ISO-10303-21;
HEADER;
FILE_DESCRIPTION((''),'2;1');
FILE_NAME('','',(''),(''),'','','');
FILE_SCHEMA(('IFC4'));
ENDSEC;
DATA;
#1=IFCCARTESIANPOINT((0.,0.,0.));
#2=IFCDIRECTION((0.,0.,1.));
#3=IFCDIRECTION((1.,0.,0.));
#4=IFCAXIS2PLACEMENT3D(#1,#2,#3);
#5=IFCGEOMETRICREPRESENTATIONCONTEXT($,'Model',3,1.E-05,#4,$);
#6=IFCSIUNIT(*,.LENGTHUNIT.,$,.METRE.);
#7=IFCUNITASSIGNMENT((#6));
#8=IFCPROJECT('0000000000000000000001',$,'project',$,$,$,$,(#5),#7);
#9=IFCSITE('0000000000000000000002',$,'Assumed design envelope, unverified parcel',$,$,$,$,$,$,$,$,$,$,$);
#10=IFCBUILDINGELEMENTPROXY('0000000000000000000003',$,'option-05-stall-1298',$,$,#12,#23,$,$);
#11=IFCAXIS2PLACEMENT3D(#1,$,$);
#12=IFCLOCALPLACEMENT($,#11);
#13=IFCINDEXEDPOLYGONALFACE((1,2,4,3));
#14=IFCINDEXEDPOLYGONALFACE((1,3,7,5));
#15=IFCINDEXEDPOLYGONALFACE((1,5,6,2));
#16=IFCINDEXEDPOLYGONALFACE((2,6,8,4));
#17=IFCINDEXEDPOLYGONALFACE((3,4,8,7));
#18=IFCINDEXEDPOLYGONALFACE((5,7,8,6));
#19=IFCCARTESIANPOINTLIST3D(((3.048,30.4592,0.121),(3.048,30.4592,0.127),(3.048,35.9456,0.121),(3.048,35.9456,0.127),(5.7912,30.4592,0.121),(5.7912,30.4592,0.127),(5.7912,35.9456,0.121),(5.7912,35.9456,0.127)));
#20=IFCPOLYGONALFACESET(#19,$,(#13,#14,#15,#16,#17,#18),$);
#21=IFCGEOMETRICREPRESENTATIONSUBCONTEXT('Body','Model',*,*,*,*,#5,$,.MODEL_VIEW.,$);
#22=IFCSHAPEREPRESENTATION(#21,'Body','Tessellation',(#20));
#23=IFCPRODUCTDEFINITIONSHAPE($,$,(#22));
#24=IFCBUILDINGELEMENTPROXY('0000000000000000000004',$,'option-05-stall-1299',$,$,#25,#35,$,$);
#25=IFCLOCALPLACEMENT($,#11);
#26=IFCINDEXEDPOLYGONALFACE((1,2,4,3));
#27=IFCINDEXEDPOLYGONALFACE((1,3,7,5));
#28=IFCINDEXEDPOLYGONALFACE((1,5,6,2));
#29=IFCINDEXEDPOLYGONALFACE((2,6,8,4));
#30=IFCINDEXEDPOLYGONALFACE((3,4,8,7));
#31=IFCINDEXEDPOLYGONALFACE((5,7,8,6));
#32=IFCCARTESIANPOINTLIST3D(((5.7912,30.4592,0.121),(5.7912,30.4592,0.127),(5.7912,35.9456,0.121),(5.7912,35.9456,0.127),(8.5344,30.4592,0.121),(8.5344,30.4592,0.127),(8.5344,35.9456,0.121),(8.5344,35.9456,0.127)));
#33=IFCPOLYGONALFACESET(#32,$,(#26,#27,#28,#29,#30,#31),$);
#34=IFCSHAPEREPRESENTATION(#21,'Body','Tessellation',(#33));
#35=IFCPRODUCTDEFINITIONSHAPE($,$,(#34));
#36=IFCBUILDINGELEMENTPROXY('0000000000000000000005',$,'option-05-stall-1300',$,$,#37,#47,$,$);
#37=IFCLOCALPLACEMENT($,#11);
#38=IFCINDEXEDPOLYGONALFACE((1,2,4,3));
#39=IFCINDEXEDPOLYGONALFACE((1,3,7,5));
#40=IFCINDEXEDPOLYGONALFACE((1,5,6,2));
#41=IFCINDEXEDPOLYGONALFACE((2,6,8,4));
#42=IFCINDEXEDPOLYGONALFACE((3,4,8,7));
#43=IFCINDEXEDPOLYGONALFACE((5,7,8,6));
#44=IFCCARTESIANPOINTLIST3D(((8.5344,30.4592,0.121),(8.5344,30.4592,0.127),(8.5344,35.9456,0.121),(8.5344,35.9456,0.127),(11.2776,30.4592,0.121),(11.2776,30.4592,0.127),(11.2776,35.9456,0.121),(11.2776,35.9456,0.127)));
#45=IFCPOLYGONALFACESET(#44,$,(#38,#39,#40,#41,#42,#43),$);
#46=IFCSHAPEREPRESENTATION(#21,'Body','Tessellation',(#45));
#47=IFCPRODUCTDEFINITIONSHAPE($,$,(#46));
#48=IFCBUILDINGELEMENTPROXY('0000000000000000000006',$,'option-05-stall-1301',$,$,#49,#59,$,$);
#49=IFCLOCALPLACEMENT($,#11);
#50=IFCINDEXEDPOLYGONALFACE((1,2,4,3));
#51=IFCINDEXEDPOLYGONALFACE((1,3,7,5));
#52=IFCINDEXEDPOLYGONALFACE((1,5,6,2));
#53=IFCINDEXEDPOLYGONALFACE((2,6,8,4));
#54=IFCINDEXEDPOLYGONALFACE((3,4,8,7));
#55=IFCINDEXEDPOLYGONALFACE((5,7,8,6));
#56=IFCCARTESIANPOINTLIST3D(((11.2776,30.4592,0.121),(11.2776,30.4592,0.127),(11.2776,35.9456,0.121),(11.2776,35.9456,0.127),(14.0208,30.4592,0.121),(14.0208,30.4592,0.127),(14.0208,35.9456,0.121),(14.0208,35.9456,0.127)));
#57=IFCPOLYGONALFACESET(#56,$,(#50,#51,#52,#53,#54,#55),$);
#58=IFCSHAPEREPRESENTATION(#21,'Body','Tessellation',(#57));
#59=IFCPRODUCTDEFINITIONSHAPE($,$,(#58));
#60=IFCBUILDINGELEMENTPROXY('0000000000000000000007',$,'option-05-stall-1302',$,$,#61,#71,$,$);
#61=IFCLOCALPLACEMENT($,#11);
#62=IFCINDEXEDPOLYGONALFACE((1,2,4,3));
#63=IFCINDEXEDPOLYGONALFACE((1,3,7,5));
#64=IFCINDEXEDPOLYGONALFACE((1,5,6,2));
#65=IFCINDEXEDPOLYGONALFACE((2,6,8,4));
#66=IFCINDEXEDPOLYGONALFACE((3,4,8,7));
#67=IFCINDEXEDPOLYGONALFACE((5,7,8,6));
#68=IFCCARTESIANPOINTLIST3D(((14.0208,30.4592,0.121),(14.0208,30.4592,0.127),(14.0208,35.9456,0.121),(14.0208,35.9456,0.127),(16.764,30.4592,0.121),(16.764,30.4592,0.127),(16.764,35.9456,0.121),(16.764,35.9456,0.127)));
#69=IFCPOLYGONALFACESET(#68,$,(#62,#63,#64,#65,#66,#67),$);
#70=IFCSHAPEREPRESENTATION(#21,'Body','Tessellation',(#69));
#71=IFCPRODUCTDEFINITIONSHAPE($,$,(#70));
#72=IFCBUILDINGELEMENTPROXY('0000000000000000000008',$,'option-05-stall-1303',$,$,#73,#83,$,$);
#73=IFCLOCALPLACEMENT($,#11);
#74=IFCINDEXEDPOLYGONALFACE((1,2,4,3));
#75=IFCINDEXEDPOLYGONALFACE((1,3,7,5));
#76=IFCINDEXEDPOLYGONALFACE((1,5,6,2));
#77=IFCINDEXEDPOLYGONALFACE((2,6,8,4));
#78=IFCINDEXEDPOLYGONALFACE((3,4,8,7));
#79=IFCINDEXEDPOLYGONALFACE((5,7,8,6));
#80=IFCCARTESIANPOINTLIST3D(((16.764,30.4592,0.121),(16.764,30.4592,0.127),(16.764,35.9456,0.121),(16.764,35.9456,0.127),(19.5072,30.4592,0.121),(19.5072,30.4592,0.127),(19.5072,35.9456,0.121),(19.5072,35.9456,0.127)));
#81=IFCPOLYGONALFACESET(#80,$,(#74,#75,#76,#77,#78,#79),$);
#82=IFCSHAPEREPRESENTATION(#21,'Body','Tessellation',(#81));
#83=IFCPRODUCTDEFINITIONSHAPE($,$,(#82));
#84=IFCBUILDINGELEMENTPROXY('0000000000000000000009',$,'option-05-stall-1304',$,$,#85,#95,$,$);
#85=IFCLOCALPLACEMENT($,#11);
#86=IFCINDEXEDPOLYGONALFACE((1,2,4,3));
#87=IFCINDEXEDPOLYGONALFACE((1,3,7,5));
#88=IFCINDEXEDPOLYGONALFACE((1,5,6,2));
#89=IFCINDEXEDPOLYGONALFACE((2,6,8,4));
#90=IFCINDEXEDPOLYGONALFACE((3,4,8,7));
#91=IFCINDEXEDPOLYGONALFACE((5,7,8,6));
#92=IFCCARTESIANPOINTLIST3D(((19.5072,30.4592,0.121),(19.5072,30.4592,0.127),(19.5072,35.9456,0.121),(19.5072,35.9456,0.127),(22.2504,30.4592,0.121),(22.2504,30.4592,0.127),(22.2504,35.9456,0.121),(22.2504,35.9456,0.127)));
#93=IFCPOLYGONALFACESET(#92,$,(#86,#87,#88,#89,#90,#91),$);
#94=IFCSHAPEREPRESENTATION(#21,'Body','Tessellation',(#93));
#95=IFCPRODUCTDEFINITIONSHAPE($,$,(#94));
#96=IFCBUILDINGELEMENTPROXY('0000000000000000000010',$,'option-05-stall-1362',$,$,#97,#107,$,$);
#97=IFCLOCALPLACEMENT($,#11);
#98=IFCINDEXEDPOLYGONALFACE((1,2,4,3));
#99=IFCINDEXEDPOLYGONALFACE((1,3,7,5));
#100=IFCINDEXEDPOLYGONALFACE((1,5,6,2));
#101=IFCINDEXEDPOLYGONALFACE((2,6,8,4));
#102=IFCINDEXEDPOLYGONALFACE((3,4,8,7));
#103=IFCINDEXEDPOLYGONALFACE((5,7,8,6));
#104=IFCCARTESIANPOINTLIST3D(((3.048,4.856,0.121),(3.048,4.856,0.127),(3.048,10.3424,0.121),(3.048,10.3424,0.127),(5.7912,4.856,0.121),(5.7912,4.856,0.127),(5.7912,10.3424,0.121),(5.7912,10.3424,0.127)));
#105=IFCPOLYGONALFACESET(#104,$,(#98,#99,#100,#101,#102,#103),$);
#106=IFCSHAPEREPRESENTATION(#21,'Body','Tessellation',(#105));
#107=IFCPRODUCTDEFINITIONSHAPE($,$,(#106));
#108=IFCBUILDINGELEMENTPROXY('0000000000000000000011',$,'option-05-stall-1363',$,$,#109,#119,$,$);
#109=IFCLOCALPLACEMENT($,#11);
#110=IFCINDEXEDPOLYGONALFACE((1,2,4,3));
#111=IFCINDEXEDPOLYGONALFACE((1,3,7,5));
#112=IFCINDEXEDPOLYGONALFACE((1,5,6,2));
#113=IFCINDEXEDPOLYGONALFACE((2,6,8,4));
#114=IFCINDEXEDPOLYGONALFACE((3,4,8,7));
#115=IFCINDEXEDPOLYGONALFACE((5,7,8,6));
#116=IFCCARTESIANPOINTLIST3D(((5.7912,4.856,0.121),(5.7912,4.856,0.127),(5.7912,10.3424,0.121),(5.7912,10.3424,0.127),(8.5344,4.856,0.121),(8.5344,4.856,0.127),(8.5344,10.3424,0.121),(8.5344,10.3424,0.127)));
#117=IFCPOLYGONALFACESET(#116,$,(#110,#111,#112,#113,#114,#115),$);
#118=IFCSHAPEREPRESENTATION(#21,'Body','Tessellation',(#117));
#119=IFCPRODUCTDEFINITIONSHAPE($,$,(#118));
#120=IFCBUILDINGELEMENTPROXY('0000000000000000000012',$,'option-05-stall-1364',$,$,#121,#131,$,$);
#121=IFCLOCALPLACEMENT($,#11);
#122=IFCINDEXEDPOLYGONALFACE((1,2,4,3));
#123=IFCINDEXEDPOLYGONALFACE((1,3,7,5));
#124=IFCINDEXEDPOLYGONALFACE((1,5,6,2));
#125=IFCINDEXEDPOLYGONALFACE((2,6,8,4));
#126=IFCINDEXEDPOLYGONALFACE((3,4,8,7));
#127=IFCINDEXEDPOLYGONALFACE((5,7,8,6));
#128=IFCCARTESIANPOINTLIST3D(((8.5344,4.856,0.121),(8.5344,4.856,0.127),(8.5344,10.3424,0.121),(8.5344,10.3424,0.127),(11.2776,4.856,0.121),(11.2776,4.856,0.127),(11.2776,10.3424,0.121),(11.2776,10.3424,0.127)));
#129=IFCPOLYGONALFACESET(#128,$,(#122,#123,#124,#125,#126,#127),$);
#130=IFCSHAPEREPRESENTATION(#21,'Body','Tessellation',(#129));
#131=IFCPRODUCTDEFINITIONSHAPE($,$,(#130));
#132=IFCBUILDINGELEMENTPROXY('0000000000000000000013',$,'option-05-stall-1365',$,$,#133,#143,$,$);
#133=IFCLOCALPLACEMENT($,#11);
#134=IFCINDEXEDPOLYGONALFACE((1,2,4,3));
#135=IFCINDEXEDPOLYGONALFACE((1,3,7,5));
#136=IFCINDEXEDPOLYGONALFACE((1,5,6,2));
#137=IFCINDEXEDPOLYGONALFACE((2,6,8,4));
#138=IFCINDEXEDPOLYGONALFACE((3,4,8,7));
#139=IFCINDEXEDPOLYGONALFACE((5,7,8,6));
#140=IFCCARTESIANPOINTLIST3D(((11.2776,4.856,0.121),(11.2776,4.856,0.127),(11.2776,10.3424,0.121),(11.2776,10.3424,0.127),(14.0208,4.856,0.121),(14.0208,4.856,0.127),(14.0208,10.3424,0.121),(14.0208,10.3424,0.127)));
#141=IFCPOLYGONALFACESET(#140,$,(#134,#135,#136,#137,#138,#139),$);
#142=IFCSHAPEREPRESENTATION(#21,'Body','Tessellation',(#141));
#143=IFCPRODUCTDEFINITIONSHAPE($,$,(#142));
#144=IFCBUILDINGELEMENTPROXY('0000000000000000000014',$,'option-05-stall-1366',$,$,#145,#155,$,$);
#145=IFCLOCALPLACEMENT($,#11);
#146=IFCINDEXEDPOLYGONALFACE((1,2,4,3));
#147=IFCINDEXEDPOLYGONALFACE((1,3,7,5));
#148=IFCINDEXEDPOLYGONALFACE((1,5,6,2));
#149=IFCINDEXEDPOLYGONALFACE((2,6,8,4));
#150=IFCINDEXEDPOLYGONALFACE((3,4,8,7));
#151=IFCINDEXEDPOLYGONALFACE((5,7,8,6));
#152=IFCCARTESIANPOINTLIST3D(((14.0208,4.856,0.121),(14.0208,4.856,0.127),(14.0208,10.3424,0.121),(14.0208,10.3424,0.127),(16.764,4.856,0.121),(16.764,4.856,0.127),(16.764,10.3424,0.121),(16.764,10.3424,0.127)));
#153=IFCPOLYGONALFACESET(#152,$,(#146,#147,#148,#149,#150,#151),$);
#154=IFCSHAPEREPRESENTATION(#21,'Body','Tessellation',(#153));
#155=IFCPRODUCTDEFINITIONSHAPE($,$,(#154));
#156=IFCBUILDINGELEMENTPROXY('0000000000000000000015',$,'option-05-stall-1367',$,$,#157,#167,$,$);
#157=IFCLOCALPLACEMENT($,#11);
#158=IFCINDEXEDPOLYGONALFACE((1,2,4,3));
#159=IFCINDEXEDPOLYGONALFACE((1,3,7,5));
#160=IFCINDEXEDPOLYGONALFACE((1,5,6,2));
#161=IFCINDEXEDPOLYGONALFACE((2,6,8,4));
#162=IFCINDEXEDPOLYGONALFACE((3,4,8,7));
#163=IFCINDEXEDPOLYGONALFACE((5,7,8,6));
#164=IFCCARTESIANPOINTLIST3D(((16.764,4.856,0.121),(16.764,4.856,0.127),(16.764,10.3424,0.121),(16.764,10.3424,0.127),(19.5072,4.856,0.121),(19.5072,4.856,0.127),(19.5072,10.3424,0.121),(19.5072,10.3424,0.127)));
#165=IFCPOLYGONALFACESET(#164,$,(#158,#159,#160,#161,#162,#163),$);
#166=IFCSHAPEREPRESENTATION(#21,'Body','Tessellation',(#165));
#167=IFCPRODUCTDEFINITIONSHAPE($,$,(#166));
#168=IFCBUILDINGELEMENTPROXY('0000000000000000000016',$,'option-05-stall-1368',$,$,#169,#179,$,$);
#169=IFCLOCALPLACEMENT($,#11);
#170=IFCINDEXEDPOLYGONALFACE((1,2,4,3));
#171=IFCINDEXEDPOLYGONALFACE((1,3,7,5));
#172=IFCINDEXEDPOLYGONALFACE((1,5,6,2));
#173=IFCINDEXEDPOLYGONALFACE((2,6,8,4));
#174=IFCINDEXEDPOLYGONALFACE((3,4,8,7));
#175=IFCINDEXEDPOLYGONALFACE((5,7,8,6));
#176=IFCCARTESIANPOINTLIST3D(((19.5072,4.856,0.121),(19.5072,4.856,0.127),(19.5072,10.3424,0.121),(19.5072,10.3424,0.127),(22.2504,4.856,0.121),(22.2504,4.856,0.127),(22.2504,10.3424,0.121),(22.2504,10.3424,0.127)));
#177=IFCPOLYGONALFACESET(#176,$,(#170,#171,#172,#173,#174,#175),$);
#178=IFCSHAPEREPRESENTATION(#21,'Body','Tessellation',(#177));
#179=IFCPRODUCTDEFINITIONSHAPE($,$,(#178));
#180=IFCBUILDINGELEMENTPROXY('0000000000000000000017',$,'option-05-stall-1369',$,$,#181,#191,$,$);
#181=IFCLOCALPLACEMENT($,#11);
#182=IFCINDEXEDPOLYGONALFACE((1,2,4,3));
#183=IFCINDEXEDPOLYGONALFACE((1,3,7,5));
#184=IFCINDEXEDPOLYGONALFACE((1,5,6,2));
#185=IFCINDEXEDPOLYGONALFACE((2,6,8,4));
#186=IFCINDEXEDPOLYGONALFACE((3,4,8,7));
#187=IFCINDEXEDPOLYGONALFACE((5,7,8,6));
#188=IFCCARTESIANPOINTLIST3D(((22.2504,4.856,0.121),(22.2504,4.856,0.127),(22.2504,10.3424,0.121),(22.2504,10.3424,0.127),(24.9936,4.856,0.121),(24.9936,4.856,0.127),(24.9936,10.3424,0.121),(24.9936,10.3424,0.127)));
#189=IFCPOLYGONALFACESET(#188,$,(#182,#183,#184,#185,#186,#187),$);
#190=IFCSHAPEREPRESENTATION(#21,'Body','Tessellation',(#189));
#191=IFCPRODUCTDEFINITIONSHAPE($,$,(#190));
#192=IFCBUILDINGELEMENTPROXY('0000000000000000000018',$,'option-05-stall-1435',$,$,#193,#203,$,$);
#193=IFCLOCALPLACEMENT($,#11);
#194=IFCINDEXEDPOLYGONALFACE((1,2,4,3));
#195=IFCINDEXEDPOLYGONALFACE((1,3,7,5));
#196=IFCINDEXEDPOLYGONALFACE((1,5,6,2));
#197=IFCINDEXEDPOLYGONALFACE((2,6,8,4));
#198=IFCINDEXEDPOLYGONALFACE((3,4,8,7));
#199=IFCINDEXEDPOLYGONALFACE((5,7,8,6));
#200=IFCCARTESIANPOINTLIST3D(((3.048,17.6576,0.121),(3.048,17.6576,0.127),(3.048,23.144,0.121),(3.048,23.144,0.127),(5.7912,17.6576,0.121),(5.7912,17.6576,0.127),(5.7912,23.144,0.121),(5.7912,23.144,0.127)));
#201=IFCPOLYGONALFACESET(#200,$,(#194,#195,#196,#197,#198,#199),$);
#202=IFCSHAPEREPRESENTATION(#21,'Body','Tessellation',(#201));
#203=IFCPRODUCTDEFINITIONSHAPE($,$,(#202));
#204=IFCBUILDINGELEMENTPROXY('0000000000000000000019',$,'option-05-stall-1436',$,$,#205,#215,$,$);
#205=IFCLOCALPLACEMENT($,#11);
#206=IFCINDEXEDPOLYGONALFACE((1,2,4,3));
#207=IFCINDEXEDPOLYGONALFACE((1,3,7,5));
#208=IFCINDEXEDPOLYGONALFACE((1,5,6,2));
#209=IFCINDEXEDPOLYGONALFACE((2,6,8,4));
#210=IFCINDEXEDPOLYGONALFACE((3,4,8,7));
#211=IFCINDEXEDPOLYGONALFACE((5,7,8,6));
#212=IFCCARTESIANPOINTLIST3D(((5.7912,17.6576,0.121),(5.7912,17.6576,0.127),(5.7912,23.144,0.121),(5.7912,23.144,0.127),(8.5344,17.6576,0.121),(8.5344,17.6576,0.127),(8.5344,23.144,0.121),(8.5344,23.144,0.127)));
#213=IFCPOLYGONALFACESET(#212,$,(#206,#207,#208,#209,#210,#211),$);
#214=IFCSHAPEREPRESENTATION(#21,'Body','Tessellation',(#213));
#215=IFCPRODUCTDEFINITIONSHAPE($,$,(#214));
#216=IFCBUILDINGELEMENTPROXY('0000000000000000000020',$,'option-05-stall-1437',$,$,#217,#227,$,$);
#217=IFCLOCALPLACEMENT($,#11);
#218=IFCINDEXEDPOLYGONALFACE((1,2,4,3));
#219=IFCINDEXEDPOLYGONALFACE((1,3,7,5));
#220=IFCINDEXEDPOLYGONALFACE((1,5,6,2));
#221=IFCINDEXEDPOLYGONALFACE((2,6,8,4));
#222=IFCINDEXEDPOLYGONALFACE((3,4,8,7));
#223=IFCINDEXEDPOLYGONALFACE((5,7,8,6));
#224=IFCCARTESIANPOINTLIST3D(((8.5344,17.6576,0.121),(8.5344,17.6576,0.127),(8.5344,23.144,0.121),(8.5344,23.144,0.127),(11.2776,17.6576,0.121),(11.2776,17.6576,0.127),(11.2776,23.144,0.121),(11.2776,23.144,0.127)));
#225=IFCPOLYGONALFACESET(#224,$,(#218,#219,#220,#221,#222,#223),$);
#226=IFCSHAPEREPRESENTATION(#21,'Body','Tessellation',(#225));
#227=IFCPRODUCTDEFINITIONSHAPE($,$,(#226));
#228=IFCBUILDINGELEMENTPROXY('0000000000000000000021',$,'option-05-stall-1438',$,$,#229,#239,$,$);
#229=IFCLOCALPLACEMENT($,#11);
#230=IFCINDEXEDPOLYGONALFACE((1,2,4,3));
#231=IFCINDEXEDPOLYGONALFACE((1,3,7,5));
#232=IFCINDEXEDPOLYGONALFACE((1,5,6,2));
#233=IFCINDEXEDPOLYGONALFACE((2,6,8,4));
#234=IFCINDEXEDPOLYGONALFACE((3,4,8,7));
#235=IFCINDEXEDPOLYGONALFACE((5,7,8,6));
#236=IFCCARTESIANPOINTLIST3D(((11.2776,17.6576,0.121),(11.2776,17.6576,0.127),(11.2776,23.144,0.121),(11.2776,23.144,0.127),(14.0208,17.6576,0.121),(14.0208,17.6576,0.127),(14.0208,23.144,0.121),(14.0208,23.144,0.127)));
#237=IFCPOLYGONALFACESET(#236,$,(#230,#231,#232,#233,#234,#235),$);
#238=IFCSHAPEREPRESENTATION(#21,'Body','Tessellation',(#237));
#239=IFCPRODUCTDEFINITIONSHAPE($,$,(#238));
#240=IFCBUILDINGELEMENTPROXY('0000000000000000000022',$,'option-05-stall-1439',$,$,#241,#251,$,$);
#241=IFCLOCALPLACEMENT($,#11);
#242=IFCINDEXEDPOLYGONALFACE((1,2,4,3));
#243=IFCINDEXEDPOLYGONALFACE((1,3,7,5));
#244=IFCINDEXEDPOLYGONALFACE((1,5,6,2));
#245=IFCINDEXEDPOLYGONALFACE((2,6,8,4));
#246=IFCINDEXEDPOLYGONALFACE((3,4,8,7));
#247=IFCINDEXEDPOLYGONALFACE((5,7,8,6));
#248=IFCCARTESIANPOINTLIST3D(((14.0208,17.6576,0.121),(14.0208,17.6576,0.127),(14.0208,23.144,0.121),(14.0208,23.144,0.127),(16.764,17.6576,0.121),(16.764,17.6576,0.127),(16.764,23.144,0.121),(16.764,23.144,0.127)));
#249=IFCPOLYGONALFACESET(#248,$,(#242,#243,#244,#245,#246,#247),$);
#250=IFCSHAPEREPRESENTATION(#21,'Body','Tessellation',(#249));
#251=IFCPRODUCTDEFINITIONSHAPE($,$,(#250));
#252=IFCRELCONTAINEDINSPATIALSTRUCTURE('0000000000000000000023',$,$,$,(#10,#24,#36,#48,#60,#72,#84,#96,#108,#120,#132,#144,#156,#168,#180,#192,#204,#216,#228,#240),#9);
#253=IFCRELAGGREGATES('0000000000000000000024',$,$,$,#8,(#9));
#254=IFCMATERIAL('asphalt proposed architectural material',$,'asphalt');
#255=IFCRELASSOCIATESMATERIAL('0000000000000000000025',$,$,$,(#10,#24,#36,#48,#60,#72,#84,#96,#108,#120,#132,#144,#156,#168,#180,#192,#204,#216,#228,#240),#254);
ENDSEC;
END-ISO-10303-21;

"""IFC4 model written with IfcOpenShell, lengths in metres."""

from ifc_helpers import new_model, si_unit, frame, origin_with_axes, place, context, subcontext, project, spatial, rectangle, extrude, material, element, save


model = new_model("IFC4")

# Units and contexts
model_context = context("Model", 3, precision=1e-05, world=origin_with_axes())
body_context = subcontext(model_context, "Body", "Model", "MODEL_VIEW")
ifc_project = project(units=[si_unit("LENGTHUNIT", "METRE")], contexts=[model_context])

# Site
site = spatial("IfcSite", under=ifc_project, Name="Assumed design envelope, unverified parcel")

# Building element proxies
ifc_material_1 = material(Name="asphalt proposed architectural material", Category="asphalt")
for number, where, z_axis, x_axis, name in (
    (1, (4.4196, 33.2024, 0.121), (0.0, 0.0, 1.0), (1.0, 0.0, 0.0), "option-05-stall-1298"),
    (2, (7.1628, 33.2024, 0.121), (0.0, 0.0, 1.0), (1.0, 0.0, 0.0), "option-05-stall-1299"),
    (3, (9.906, 33.2024, 0.121), (0.0, 0.0, 1.0), (1.0, 0.0, 0.0), "option-05-stall-1300"),
    (4, (12.6492, 33.2024, 0.121), (0.0, 0.0, 1.0), (1.0, 0.0, 0.0), "option-05-stall-1301"),
    (5, (15.3924, 33.2024, 0.121), (0.0, 0.0, 1.0), (1.0, 0.0, 0.0), "option-05-stall-1302"),
):
    element("IfcBuildingElementProxy", number, at=place(None, frame(where, z_axis=z_axis, x_axis=x_axis)), inside=site, material=ifc_material_1, Name=name, context=body_context, shape_type="SweptSolid", body=[
        extrude(rectangle(XDim=2.7432, YDim=5.4864), origin_with_axes(), (0.0, 0.0, 1.0), 0.006),
    ])
for number, where, z_axis, x_axis, name in (
    (6, (18.1356, 33.2024, 0.121), (0.0, 0.0, 1.0), (1.0, 0.0, 0.0), "option-05-stall-1303"),
    (7, (20.8788, 33.2024, 0.121), (0.0, 0.0, 1.0), (1.0, 0.0, 0.0), "option-05-stall-1304"),
):
    element("IfcBuildingElementProxy", number, at=place(None, frame(where, z_axis=z_axis, x_axis=x_axis)), inside=site, material=ifc_material_1, Name=name, context=body_context, shape_type="SweptSolid", body=[
        extrude(rectangle(XDim=2.7432, YDim=5.4864), origin_with_axes(), (0.0, 0.0, 1.0), 0.006),
    ])
for number, where, z_axis, x_axis, name in (
    (8, (4.4196, 7.5992, 0.121), (0.0, 0.0, 1.0), (1.0, 0.0, 0.0), "option-05-stall-1362"),
    (9, (7.1628, 7.5992, 0.121), (0.0, 0.0, 1.0), (1.0, 0.0, 0.0), "option-05-stall-1363"),
    (10, (9.906, 7.5992, 0.121), (0.0, 0.0, 1.0), (1.0, 0.0, 0.0), "option-05-stall-1364"),
    (11, (12.6492, 7.5992, 0.121), (0.0, 0.0, 1.0), (1.0, 0.0, 0.0), "option-05-stall-1365"),
    (12, (15.3924, 7.5992, 0.121), (0.0, 0.0, 1.0), (1.0, 0.0, 0.0), "option-05-stall-1366"),
):
    element("IfcBuildingElementProxy", number, at=place(None, frame(where, z_axis=z_axis, x_axis=x_axis)), inside=site, material=ifc_material_1, Name=name, context=body_context, shape_type="SweptSolid", body=[
        extrude(rectangle(XDim=2.7432, YDim=5.4864), origin_with_axes(), (0.0, 0.0, 1.0), 0.006),
    ])
for number, where, z_axis, x_axis, name in (
    (13, (18.1356, 7.5992, 0.121), (0.0, 0.0, 1.0), (1.0, 0.0, 0.0), "option-05-stall-1367"),
    (14, (20.8788, 7.5992, 0.121), (0.0, 0.0, 1.0), (1.0, 0.0, 0.0), "option-05-stall-1368"),
    (15, (23.622, 7.5992, 0.121), (0.0, 0.0, 1.0), (1.0, 0.0, 0.0), "option-05-stall-1369"),
):
    element("IfcBuildingElementProxy", number, at=place(None, frame(where, z_axis=z_axis, x_axis=x_axis)), inside=site, material=ifc_material_1, Name=name, context=body_context, shape_type="SweptSolid", body=[
        extrude(rectangle(XDim=2.7432, YDim=5.4864), origin_with_axes(), (0.0, 0.0, 1.0), 0.006),
    ])
for number, where, z_axis, x_axis, name in (
    (16, (4.4196, 20.4008, 0.121), (0.0, 0.0, 1.0), (1.0, 0.0, 0.0), "option-05-stall-1435"),
    (17, (7.1628, 20.4008, 0.121), (0.0, 0.0, 1.0), (1.0, 0.0, 0.0), "option-05-stall-1436"),
    (18, (9.906, 20.4008, 0.121), (0.0, 0.0, 1.0), (1.0, 0.0, 0.0), "option-05-stall-1437"),
    (19, (12.6492, 20.4008, 0.121), (0.0, 0.0, 1.0), (1.0, 0.0, 0.0), "option-05-stall-1438"),
    (20, (15.3924, 20.4008, 0.121), (0.0, 0.0, 1.0), (1.0, 0.0, 0.0), "option-05-stall-1439"),
):
    element("IfcBuildingElementProxy", number, at=place(None, frame(where, z_axis=z_axis, x_axis=x_axis)), inside=site, material=ifc_material_1, Name=name, context=body_context, shape_type="SweptSolid", body=[
        extrude(rectangle(XDim=2.7432, YDim=5.4864), origin_with_axes(), (0.0, 0.0, 1.0), 0.006),
    ])

save(model, "model.ifc")
